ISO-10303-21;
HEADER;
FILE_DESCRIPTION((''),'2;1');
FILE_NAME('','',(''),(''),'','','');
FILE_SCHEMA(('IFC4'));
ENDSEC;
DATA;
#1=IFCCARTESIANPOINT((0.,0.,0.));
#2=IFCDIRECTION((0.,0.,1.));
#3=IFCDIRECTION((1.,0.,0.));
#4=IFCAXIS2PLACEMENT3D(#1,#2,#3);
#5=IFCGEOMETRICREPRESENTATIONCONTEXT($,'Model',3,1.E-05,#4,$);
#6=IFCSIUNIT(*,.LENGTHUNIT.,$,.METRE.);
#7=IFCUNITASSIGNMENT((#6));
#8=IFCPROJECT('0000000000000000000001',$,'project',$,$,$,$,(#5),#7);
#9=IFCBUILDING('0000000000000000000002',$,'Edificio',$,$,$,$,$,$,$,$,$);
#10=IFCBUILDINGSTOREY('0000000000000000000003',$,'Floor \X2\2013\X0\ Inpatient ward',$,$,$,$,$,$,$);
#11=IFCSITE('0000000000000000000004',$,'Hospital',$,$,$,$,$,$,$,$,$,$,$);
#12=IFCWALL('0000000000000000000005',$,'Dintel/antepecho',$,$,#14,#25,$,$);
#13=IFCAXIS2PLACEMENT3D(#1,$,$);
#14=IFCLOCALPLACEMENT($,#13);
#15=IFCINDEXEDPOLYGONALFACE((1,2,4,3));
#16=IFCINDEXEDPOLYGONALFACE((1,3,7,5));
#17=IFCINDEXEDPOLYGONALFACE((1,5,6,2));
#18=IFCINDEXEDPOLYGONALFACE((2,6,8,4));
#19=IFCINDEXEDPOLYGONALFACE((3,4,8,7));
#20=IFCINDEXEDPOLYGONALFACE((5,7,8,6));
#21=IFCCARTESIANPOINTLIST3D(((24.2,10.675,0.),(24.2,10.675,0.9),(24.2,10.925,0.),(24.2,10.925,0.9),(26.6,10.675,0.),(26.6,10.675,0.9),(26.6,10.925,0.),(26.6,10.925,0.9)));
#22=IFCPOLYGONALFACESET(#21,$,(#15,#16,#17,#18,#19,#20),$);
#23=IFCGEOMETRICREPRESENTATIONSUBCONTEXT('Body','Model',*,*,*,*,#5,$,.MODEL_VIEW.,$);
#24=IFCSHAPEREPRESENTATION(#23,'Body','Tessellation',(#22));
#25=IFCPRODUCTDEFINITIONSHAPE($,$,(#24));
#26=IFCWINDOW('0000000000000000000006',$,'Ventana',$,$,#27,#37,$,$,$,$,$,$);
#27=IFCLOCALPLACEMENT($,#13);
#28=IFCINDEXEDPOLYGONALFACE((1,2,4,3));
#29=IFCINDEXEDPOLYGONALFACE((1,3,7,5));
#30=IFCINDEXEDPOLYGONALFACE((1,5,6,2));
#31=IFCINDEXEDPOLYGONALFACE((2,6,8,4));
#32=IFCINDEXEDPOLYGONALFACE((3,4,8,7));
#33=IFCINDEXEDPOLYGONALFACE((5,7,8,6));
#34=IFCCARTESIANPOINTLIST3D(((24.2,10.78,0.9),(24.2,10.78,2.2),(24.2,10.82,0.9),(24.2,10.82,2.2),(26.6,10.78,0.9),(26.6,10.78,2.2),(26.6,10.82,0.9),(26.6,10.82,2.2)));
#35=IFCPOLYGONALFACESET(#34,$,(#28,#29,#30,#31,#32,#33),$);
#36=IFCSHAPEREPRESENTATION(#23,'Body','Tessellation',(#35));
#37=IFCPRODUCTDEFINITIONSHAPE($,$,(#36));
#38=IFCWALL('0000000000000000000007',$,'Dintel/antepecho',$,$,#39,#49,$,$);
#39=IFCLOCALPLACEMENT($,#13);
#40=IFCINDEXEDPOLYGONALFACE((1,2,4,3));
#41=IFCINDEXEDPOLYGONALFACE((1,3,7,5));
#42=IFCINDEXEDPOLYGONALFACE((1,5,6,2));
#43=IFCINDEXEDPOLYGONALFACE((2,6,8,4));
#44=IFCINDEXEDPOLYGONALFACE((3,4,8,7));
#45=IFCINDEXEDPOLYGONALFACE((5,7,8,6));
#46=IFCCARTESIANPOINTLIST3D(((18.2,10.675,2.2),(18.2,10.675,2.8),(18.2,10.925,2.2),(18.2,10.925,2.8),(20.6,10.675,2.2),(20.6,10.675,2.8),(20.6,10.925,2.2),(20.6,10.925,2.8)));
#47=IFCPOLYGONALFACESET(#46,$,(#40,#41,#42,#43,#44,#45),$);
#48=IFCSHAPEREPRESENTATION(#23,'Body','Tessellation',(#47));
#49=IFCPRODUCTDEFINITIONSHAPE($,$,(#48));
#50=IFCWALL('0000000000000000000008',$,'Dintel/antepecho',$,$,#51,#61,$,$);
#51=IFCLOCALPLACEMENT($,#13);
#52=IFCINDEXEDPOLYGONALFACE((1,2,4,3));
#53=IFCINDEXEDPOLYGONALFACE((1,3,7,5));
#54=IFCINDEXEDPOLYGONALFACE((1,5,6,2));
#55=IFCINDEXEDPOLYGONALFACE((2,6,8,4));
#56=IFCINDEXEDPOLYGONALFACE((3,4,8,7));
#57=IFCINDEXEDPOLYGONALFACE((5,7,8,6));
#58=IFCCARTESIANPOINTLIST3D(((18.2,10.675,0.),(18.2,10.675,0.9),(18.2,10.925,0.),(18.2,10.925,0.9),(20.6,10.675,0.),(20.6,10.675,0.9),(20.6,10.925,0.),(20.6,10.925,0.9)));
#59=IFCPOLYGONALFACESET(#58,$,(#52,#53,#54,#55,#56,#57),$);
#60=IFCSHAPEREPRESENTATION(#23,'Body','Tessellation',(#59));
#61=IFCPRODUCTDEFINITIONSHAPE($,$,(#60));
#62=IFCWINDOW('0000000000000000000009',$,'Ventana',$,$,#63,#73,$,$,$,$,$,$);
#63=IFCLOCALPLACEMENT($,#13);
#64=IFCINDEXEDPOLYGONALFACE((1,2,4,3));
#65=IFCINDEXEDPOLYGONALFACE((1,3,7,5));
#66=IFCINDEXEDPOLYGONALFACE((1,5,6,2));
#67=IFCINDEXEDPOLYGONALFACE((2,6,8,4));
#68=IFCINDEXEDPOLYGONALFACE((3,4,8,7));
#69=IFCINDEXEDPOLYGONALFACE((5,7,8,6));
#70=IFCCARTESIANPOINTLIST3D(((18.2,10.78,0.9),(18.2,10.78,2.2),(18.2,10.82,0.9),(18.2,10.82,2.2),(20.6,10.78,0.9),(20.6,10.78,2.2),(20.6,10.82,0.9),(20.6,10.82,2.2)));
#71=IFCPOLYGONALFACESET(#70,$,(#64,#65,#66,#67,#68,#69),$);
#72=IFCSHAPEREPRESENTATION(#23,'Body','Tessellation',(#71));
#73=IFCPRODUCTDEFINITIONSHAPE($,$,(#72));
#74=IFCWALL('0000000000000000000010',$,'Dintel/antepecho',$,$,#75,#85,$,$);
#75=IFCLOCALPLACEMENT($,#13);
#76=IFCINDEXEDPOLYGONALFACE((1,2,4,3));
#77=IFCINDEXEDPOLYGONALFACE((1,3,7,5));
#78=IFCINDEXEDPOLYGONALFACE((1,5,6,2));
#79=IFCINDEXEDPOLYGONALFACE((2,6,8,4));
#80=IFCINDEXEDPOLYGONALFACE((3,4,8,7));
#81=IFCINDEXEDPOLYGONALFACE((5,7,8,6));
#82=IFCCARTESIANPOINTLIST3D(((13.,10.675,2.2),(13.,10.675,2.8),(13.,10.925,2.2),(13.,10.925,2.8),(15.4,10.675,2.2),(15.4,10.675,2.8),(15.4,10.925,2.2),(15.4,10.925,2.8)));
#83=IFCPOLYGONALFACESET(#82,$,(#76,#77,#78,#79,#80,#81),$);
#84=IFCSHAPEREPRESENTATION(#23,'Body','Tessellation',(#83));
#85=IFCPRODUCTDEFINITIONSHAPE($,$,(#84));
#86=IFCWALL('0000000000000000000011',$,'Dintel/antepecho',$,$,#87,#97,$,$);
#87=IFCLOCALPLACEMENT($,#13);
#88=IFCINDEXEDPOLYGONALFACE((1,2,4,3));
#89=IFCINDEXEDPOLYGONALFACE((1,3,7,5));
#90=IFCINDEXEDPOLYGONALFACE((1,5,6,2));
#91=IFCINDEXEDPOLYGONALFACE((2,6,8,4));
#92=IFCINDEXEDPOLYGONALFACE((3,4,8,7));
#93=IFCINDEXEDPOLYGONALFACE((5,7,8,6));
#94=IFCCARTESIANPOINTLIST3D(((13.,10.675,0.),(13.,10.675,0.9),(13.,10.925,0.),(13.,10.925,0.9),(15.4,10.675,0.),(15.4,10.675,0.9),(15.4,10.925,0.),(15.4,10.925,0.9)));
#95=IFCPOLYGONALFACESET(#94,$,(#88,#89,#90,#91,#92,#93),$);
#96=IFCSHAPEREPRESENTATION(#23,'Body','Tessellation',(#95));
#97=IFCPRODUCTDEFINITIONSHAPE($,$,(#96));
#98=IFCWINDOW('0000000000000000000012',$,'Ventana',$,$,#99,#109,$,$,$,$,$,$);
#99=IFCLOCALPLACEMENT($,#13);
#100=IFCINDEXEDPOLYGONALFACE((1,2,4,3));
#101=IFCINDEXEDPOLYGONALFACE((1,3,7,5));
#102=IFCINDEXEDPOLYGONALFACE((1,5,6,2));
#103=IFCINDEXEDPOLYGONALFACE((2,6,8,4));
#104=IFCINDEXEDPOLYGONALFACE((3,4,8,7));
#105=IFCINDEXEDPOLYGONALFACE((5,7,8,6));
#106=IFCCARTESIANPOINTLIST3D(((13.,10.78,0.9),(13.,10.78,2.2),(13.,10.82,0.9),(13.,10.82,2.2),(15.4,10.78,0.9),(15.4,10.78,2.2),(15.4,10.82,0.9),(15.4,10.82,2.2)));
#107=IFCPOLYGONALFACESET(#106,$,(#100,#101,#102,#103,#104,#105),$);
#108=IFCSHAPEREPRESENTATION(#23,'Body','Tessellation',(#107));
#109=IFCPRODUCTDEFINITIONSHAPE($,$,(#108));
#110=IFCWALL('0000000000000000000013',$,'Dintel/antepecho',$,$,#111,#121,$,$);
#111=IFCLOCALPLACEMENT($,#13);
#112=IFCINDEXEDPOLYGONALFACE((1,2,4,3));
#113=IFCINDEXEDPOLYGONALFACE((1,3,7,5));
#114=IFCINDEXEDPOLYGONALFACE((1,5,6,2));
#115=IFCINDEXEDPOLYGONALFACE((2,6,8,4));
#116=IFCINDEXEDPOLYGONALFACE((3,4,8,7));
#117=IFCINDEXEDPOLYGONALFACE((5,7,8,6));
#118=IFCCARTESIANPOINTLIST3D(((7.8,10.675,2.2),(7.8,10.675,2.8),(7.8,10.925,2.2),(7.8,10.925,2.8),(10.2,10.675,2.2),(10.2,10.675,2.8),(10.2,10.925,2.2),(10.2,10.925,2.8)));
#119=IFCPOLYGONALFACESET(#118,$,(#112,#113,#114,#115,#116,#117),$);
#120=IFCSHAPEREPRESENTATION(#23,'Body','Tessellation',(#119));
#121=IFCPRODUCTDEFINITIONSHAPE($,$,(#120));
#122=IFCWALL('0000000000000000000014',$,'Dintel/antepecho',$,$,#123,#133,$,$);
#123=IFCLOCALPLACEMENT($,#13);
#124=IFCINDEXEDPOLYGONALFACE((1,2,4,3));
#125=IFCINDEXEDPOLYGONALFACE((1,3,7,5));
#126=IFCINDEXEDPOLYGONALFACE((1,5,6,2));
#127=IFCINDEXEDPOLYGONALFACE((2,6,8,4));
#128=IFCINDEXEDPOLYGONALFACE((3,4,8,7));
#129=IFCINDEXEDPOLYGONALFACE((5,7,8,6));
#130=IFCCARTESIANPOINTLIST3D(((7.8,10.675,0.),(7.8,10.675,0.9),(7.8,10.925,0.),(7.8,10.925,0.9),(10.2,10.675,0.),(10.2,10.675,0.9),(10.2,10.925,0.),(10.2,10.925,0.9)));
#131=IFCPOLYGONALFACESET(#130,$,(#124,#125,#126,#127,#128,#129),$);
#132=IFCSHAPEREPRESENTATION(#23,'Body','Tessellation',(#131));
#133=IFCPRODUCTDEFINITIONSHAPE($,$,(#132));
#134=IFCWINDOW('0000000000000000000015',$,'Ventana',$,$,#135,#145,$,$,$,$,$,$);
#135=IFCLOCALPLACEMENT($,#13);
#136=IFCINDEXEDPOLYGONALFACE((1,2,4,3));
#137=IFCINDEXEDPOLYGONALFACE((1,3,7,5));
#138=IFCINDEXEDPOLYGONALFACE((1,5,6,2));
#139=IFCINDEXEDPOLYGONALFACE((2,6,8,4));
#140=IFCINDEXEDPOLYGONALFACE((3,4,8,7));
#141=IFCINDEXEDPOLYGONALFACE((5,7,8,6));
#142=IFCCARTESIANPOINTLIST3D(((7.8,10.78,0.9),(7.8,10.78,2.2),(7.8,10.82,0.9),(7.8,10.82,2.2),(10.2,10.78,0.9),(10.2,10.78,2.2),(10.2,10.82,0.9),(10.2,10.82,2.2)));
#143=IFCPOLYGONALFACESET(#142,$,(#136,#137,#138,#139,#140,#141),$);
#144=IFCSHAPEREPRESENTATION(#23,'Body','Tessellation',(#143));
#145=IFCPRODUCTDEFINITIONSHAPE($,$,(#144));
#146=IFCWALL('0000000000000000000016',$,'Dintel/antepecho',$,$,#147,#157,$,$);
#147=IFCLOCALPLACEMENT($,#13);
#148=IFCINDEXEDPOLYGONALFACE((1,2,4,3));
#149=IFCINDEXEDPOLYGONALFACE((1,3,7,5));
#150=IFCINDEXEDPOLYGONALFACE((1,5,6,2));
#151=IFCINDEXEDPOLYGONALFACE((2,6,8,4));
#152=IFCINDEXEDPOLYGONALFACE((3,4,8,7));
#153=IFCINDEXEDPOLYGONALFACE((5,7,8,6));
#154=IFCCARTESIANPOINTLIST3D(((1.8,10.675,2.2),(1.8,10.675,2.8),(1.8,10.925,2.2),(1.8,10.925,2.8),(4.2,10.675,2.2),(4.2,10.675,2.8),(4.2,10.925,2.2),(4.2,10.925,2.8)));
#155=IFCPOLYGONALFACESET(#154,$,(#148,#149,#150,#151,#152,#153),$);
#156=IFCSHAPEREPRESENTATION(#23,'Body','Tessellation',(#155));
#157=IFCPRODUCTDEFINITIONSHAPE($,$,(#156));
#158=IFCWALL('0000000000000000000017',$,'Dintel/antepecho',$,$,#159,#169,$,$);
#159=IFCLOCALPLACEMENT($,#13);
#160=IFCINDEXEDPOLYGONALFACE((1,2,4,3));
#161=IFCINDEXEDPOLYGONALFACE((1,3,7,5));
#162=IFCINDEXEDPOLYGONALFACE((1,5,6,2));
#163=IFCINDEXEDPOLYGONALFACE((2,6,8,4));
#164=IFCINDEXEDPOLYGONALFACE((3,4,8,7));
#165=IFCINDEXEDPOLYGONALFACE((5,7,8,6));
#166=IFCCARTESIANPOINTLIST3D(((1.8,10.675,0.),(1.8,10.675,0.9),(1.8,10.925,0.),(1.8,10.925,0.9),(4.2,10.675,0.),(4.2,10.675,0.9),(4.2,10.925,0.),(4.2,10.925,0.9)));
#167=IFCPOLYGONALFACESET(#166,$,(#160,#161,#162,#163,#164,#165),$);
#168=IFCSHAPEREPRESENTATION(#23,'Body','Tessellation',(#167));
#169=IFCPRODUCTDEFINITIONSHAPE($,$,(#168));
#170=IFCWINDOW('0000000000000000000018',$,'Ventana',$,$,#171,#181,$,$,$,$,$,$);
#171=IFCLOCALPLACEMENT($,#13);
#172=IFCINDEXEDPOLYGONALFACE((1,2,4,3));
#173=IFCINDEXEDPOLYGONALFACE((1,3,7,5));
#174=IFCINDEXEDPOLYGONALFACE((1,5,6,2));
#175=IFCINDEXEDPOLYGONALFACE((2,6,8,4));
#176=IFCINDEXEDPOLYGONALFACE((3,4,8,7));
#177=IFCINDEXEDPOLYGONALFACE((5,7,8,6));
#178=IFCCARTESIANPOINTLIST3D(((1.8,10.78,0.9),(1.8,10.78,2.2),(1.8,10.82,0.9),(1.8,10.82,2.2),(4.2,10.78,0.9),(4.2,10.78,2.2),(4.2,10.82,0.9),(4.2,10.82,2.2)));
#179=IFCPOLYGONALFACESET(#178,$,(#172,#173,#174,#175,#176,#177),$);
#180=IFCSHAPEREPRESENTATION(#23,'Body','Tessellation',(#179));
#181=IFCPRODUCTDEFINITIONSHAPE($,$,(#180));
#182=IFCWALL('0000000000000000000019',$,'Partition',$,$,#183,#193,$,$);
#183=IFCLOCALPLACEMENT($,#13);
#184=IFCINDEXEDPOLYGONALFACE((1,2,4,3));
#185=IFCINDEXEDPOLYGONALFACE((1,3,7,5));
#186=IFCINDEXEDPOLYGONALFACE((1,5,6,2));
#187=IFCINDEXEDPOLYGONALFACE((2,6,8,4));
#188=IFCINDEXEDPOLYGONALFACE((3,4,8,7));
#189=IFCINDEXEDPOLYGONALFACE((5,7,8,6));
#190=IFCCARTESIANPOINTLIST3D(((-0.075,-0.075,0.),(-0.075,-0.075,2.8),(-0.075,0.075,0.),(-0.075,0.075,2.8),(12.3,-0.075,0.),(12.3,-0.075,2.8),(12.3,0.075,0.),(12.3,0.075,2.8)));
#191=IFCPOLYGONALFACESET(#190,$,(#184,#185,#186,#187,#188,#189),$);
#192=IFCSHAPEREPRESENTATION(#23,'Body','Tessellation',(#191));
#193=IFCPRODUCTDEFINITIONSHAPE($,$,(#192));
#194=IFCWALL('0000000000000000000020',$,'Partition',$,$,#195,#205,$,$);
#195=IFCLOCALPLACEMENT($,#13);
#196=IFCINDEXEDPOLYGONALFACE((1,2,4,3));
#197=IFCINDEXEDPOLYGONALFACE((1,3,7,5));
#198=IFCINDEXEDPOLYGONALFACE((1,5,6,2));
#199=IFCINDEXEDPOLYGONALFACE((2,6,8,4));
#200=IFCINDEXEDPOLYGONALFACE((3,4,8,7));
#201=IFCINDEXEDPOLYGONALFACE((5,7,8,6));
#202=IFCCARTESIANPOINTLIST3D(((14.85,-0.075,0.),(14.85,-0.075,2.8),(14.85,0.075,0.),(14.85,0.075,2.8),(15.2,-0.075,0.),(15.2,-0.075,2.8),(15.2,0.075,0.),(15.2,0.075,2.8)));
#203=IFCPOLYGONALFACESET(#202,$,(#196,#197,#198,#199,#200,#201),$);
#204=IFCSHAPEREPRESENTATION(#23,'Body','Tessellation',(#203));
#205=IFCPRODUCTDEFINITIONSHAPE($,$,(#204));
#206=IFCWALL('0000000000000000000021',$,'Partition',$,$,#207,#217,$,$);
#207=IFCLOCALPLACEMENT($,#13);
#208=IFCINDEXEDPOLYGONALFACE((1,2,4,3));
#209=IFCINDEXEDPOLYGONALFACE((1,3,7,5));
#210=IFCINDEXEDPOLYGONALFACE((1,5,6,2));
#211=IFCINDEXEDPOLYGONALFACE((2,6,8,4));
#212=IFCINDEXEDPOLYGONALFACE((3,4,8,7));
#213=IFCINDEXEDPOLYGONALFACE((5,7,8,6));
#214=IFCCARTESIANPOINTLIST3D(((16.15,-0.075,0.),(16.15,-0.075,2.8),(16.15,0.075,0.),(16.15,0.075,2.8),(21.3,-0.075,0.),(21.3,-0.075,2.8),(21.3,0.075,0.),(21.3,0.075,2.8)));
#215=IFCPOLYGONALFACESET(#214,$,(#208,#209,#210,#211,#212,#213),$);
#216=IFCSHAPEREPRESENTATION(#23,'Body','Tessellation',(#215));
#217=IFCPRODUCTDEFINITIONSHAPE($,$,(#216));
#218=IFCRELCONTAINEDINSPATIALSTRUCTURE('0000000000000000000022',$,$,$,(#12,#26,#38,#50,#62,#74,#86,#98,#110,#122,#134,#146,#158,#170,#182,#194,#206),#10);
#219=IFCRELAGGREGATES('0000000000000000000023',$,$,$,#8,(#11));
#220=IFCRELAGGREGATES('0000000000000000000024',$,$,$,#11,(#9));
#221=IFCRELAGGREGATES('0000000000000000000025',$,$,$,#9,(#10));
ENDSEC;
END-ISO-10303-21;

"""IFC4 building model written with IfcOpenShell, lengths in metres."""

from ifc_helpers import new_model, si_unit, frame, origin_with_axes, context, subcontext, project, spatial, line, indexed_curve, outline, extrude, element, save


model = new_model("IFC4")

# Units and contexts
model_context = context("Model", 3, precision=1e-05, world=origin_with_axes())
body_context = subcontext(model_context, "Body", "Model", "MODEL_VIEW")
ifc_project = project(units=[si_unit("LENGTHUNIT", "METRE")], contexts=[model_context])

# Site, building, storey
site = spatial("IfcSite", under=ifc_project, Name="Hospital")
building = spatial("IfcBuilding", under=site, Name="Edificio")
storey = spatial("IfcBuildingStorey", under=building, Name="Floor – Inpatient ward")

# Wall
element("IfcWall", 1, inside=storey, Name="Dintel/antepecho", context=body_context, shape_type="SweptSolid", body=[
    extrude(outline(indexed_curve([(0.0, 0.0), (2.4, 0.0), (2.4, 0.25), (0.0, 0.25)], segments=[line(1, 2, 3, 4, 1)])), frame((24.2, 10.675, 0.0), z_axis=(0.0, 0.0, 1.0), x_axis=(1.0, 0.0, 0.0)), (0.0, 0.0, 1.0), 0.9),
])

# Window
element("IfcWindow", 2, inside=storey, Name="Ventana", context=body_context, shape_type="SweptSolid", body=[
    extrude(outline(indexed_curve([(0.0, 0.0), (2.4, 0.0), (2.4, 0.04), (0.0, 0.04)], segments=[line(1, 2, 3, 4, 1)])), frame((24.2, 10.78, 0.9), z_axis=(0.0, 0.0, 1.0), x_axis=(1.0, 0.0, 0.0)), (0.0, 0.0, 1.0), 1.3),
])

# Walls
element("IfcWall", 3, inside=storey, Name="Dintel/antepecho", context=body_context, shape_type="SweptSolid", body=[
    extrude(outline(indexed_curve([(0.0, 0.0), (2.4, 0.0), (2.4, 0.25), (0.0, 0.25)], segments=[line(1, 2, 3, 4, 1)])), frame((18.2, 10.675, 2.2), z_axis=(0.0, 0.0, 1.0), x_axis=(1.0, 0.0, 0.0)), (0.0, 0.0, 1.0), 0.6),
])
element("IfcWall", 4, inside=storey, Name="Dintel/antepecho", context=body_context, shape_type="SweptSolid", body=[
    extrude(outline(indexed_curve([(0.0, 0.0), (2.4, 0.0), (2.4, 0.25), (0.0, 0.25)], segments=[line(1, 2, 3, 4, 1)])), frame((18.2, 10.675, 0.0), z_axis=(0.0, 0.0, 1.0), x_axis=(1.0, 0.0, 0.0)), (0.0, 0.0, 1.0), 0.9),
])

# Window
element("IfcWindow", 5, inside=storey, Name="Ventana", context=body_context, shape_type="SweptSolid", body=[
    extrude(outline(indexed_curve([(0.0, 0.0), (2.4, 0.0), (2.4, 0.04), (0.0, 0.04)], segments=[line(1, 2, 3, 4, 1)])), frame((18.2, 10.78, 0.9), z_axis=(0.0, 0.0, 1.0), x_axis=(1.0, 0.0, 0.0)), (0.0, 0.0, 1.0), 1.3),
])

# Walls
element("IfcWall", 6, inside=storey, Name="Dintel/antepecho", context=body_context, shape_type="SweptSolid", body=[
    extrude(outline(indexed_curve([(0.0, 0.0), (2.4, 0.0), (2.4, 0.25), (0.0, 0.25)], segments=[line(1, 2, 3, 4, 1)])), frame((13.0, 10.675, 2.2), z_axis=(0.0, 0.0, 1.0), x_axis=(1.0, 0.0, 0.0)), (0.0, 0.0, 1.0), 0.6),
])
element("IfcWall", 7, inside=storey, Name="Dintel/antepecho", context=body_context, shape_type="SweptSolid", body=[
    extrude(outline(indexed_curve([(0.0, 0.0), (2.4, 0.0), (2.4, 0.25), (0.0, 0.25)], segments=[line(1, 2, 3, 4, 1)])), frame((13.0, 10.675, 0.0), z_axis=(0.0, 0.0, 1.0), x_axis=(1.0, 0.0, 0.0)), (0.0, 0.0, 1.0), 0.9),
])

# Window
element("IfcWindow", 8, inside=storey, Name="Ventana", context=body_context, shape_type="SweptSolid", body=[
    extrude(outline(indexed_curve([(0.0, 0.0), (2.4, 0.0), (2.4, 0.04), (0.0, 0.04)], segments=[line(1, 2, 3, 4, 1)])), frame((13.0, 10.78, 0.9), z_axis=(0.0, 0.0, 1.0), x_axis=(1.0, 0.0, 0.0)), (0.0, 0.0, 1.0), 1.3),
])

# Walls
element("IfcWall", 9, inside=storey, Name="Dintel/antepecho", context=body_context, shape_type="SweptSolid", body=[
    extrude(outline(indexed_curve([(0.0, 0.0), (2.4, 0.0), (2.4, 0.25), (0.0, 0.25)], segments=[line(1, 2, 3, 4, 1)])), frame((7.8, 10.675, 2.2), z_axis=(0.0, 0.0, 1.0), x_axis=(1.0, 0.0, 0.0)), (0.0, 0.0, 1.0), 0.6),
])
element("IfcWall", 10, inside=storey, Name="Dintel/antepecho", context=body_context, shape_type="SweptSolid", body=[
    extrude(outline(indexed_curve([(0.0, 0.0), (2.4, 0.0), (2.4, 0.25), (0.0, 0.25)], segments=[line(1, 2, 3, 4, 1)])), frame((7.8, 10.675, 0.0), z_axis=(0.0, 0.0, 1.0), x_axis=(1.0, 0.0, 0.0)), (0.0, 0.0, 1.0), 0.9),
])

# Window
element("IfcWindow", 11, inside=storey, Name="Ventana", context=body_context, shape_type="SweptSolid", body=[
    extrude(outline(indexed_curve([(0.0, 0.0), (2.4, 0.0), (2.4, 0.04), (0.0, 0.04)], segments=[line(1, 2, 3, 4, 1)])), frame((7.8, 10.78, 0.9), z_axis=(0.0, 0.0, 1.0), x_axis=(1.0, 0.0, 0.0)), (0.0, 0.0, 1.0), 1.3),
])

# Walls
element("IfcWall", 12, inside=storey, Name="Dintel/antepecho", context=body_context, shape_type="SweptSolid", body=[
    extrude(outline(indexed_curve([(0.0, 0.0), (2.4, 0.0), (2.4, 0.25), (0.0, 0.25)], segments=[line(1, 2, 3, 4, 1)])), frame((1.8, 10.675, 2.2), z_axis=(0.0, 0.0, 1.0), x_axis=(1.0, 0.0, 0.0)), (0.0, 0.0, 1.0), 0.6),
])
element("IfcWall", 13, inside=storey, Name="Dintel/antepecho", context=body_context, shape_type="SweptSolid", body=[
    extrude(outline(indexed_curve([(0.0, 0.0), (2.4, 0.0), (2.4, 0.25), (0.0, 0.25)], segments=[line(1, 2, 3, 4, 1)])), frame((1.8, 10.675, 0.0), z_axis=(0.0, 0.0, 1.0), x_axis=(1.0, 0.0, 0.0)), (0.0, 0.0, 1.0), 0.9),
])

# Window
element("IfcWindow", 14, inside=storey, Name="Ventana", context=body_context, shape_type="SweptSolid", body=[
    extrude(outline(indexed_curve([(0.0, 0.0), (2.4, 0.0), (2.4, 0.04), (0.0, 0.04)], segments=[line(1, 2, 3, 4, 1)])), frame((1.8, 10.78, 0.9), z_axis=(0.0, 0.0, 1.0), x_axis=(1.0, 0.0, 0.0)), (0.0, 0.0, 1.0), 1.3),
])

# Walls
element("IfcWall", 15, inside=storey, Name="Partition", context=body_context, shape_type="SweptSolid", body=[
    extrude(outline(indexed_curve([(0.0, 0.0), (12.375, 0.0), (12.375, 0.15), (0.0, 0.15)], segments=[line(1, 2, 3, 4, 1)])), frame((-0.075, -0.075, 0.0), z_axis=(0.0, 0.0, 1.0), x_axis=(1.0, 0.0, 0.0)), (0.0, 0.0, 1.0), 2.8),
])
element("IfcWall", 16, inside=storey, Name="Partition", context=body_context, shape_type="SweptSolid", body=[
    extrude(outline(indexed_curve([(0.0, 0.0), (0.35, 0.0), (0.35, 0.15), (0.0, 0.15)], segments=[line(1, 2, 3, 4, 1)])), frame((14.85, -0.075, 0.0), z_axis=(0.0, 0.0, 1.0), x_axis=(1.0, 0.0, 0.0)), (0.0, 0.0, 1.0), 2.8),
])
element("IfcWall", 17, inside=storey, Name="Partition", context=body_context, shape_type="SweptSolid", body=[
    extrude(outline(indexed_curve([(0.0, 0.0), (5.15, 0.0), (5.15, 0.15), (0.0, 0.15)], segments=[line(1, 2, 3, 4, 1)])), frame((16.15, -0.075, 0.0), z_axis=(0.0, 0.0, 1.0), x_axis=(1.0, 0.0, 0.0)), (0.0, 0.0, 1.0), 2.8),
])

save(model, "model.ifc")
